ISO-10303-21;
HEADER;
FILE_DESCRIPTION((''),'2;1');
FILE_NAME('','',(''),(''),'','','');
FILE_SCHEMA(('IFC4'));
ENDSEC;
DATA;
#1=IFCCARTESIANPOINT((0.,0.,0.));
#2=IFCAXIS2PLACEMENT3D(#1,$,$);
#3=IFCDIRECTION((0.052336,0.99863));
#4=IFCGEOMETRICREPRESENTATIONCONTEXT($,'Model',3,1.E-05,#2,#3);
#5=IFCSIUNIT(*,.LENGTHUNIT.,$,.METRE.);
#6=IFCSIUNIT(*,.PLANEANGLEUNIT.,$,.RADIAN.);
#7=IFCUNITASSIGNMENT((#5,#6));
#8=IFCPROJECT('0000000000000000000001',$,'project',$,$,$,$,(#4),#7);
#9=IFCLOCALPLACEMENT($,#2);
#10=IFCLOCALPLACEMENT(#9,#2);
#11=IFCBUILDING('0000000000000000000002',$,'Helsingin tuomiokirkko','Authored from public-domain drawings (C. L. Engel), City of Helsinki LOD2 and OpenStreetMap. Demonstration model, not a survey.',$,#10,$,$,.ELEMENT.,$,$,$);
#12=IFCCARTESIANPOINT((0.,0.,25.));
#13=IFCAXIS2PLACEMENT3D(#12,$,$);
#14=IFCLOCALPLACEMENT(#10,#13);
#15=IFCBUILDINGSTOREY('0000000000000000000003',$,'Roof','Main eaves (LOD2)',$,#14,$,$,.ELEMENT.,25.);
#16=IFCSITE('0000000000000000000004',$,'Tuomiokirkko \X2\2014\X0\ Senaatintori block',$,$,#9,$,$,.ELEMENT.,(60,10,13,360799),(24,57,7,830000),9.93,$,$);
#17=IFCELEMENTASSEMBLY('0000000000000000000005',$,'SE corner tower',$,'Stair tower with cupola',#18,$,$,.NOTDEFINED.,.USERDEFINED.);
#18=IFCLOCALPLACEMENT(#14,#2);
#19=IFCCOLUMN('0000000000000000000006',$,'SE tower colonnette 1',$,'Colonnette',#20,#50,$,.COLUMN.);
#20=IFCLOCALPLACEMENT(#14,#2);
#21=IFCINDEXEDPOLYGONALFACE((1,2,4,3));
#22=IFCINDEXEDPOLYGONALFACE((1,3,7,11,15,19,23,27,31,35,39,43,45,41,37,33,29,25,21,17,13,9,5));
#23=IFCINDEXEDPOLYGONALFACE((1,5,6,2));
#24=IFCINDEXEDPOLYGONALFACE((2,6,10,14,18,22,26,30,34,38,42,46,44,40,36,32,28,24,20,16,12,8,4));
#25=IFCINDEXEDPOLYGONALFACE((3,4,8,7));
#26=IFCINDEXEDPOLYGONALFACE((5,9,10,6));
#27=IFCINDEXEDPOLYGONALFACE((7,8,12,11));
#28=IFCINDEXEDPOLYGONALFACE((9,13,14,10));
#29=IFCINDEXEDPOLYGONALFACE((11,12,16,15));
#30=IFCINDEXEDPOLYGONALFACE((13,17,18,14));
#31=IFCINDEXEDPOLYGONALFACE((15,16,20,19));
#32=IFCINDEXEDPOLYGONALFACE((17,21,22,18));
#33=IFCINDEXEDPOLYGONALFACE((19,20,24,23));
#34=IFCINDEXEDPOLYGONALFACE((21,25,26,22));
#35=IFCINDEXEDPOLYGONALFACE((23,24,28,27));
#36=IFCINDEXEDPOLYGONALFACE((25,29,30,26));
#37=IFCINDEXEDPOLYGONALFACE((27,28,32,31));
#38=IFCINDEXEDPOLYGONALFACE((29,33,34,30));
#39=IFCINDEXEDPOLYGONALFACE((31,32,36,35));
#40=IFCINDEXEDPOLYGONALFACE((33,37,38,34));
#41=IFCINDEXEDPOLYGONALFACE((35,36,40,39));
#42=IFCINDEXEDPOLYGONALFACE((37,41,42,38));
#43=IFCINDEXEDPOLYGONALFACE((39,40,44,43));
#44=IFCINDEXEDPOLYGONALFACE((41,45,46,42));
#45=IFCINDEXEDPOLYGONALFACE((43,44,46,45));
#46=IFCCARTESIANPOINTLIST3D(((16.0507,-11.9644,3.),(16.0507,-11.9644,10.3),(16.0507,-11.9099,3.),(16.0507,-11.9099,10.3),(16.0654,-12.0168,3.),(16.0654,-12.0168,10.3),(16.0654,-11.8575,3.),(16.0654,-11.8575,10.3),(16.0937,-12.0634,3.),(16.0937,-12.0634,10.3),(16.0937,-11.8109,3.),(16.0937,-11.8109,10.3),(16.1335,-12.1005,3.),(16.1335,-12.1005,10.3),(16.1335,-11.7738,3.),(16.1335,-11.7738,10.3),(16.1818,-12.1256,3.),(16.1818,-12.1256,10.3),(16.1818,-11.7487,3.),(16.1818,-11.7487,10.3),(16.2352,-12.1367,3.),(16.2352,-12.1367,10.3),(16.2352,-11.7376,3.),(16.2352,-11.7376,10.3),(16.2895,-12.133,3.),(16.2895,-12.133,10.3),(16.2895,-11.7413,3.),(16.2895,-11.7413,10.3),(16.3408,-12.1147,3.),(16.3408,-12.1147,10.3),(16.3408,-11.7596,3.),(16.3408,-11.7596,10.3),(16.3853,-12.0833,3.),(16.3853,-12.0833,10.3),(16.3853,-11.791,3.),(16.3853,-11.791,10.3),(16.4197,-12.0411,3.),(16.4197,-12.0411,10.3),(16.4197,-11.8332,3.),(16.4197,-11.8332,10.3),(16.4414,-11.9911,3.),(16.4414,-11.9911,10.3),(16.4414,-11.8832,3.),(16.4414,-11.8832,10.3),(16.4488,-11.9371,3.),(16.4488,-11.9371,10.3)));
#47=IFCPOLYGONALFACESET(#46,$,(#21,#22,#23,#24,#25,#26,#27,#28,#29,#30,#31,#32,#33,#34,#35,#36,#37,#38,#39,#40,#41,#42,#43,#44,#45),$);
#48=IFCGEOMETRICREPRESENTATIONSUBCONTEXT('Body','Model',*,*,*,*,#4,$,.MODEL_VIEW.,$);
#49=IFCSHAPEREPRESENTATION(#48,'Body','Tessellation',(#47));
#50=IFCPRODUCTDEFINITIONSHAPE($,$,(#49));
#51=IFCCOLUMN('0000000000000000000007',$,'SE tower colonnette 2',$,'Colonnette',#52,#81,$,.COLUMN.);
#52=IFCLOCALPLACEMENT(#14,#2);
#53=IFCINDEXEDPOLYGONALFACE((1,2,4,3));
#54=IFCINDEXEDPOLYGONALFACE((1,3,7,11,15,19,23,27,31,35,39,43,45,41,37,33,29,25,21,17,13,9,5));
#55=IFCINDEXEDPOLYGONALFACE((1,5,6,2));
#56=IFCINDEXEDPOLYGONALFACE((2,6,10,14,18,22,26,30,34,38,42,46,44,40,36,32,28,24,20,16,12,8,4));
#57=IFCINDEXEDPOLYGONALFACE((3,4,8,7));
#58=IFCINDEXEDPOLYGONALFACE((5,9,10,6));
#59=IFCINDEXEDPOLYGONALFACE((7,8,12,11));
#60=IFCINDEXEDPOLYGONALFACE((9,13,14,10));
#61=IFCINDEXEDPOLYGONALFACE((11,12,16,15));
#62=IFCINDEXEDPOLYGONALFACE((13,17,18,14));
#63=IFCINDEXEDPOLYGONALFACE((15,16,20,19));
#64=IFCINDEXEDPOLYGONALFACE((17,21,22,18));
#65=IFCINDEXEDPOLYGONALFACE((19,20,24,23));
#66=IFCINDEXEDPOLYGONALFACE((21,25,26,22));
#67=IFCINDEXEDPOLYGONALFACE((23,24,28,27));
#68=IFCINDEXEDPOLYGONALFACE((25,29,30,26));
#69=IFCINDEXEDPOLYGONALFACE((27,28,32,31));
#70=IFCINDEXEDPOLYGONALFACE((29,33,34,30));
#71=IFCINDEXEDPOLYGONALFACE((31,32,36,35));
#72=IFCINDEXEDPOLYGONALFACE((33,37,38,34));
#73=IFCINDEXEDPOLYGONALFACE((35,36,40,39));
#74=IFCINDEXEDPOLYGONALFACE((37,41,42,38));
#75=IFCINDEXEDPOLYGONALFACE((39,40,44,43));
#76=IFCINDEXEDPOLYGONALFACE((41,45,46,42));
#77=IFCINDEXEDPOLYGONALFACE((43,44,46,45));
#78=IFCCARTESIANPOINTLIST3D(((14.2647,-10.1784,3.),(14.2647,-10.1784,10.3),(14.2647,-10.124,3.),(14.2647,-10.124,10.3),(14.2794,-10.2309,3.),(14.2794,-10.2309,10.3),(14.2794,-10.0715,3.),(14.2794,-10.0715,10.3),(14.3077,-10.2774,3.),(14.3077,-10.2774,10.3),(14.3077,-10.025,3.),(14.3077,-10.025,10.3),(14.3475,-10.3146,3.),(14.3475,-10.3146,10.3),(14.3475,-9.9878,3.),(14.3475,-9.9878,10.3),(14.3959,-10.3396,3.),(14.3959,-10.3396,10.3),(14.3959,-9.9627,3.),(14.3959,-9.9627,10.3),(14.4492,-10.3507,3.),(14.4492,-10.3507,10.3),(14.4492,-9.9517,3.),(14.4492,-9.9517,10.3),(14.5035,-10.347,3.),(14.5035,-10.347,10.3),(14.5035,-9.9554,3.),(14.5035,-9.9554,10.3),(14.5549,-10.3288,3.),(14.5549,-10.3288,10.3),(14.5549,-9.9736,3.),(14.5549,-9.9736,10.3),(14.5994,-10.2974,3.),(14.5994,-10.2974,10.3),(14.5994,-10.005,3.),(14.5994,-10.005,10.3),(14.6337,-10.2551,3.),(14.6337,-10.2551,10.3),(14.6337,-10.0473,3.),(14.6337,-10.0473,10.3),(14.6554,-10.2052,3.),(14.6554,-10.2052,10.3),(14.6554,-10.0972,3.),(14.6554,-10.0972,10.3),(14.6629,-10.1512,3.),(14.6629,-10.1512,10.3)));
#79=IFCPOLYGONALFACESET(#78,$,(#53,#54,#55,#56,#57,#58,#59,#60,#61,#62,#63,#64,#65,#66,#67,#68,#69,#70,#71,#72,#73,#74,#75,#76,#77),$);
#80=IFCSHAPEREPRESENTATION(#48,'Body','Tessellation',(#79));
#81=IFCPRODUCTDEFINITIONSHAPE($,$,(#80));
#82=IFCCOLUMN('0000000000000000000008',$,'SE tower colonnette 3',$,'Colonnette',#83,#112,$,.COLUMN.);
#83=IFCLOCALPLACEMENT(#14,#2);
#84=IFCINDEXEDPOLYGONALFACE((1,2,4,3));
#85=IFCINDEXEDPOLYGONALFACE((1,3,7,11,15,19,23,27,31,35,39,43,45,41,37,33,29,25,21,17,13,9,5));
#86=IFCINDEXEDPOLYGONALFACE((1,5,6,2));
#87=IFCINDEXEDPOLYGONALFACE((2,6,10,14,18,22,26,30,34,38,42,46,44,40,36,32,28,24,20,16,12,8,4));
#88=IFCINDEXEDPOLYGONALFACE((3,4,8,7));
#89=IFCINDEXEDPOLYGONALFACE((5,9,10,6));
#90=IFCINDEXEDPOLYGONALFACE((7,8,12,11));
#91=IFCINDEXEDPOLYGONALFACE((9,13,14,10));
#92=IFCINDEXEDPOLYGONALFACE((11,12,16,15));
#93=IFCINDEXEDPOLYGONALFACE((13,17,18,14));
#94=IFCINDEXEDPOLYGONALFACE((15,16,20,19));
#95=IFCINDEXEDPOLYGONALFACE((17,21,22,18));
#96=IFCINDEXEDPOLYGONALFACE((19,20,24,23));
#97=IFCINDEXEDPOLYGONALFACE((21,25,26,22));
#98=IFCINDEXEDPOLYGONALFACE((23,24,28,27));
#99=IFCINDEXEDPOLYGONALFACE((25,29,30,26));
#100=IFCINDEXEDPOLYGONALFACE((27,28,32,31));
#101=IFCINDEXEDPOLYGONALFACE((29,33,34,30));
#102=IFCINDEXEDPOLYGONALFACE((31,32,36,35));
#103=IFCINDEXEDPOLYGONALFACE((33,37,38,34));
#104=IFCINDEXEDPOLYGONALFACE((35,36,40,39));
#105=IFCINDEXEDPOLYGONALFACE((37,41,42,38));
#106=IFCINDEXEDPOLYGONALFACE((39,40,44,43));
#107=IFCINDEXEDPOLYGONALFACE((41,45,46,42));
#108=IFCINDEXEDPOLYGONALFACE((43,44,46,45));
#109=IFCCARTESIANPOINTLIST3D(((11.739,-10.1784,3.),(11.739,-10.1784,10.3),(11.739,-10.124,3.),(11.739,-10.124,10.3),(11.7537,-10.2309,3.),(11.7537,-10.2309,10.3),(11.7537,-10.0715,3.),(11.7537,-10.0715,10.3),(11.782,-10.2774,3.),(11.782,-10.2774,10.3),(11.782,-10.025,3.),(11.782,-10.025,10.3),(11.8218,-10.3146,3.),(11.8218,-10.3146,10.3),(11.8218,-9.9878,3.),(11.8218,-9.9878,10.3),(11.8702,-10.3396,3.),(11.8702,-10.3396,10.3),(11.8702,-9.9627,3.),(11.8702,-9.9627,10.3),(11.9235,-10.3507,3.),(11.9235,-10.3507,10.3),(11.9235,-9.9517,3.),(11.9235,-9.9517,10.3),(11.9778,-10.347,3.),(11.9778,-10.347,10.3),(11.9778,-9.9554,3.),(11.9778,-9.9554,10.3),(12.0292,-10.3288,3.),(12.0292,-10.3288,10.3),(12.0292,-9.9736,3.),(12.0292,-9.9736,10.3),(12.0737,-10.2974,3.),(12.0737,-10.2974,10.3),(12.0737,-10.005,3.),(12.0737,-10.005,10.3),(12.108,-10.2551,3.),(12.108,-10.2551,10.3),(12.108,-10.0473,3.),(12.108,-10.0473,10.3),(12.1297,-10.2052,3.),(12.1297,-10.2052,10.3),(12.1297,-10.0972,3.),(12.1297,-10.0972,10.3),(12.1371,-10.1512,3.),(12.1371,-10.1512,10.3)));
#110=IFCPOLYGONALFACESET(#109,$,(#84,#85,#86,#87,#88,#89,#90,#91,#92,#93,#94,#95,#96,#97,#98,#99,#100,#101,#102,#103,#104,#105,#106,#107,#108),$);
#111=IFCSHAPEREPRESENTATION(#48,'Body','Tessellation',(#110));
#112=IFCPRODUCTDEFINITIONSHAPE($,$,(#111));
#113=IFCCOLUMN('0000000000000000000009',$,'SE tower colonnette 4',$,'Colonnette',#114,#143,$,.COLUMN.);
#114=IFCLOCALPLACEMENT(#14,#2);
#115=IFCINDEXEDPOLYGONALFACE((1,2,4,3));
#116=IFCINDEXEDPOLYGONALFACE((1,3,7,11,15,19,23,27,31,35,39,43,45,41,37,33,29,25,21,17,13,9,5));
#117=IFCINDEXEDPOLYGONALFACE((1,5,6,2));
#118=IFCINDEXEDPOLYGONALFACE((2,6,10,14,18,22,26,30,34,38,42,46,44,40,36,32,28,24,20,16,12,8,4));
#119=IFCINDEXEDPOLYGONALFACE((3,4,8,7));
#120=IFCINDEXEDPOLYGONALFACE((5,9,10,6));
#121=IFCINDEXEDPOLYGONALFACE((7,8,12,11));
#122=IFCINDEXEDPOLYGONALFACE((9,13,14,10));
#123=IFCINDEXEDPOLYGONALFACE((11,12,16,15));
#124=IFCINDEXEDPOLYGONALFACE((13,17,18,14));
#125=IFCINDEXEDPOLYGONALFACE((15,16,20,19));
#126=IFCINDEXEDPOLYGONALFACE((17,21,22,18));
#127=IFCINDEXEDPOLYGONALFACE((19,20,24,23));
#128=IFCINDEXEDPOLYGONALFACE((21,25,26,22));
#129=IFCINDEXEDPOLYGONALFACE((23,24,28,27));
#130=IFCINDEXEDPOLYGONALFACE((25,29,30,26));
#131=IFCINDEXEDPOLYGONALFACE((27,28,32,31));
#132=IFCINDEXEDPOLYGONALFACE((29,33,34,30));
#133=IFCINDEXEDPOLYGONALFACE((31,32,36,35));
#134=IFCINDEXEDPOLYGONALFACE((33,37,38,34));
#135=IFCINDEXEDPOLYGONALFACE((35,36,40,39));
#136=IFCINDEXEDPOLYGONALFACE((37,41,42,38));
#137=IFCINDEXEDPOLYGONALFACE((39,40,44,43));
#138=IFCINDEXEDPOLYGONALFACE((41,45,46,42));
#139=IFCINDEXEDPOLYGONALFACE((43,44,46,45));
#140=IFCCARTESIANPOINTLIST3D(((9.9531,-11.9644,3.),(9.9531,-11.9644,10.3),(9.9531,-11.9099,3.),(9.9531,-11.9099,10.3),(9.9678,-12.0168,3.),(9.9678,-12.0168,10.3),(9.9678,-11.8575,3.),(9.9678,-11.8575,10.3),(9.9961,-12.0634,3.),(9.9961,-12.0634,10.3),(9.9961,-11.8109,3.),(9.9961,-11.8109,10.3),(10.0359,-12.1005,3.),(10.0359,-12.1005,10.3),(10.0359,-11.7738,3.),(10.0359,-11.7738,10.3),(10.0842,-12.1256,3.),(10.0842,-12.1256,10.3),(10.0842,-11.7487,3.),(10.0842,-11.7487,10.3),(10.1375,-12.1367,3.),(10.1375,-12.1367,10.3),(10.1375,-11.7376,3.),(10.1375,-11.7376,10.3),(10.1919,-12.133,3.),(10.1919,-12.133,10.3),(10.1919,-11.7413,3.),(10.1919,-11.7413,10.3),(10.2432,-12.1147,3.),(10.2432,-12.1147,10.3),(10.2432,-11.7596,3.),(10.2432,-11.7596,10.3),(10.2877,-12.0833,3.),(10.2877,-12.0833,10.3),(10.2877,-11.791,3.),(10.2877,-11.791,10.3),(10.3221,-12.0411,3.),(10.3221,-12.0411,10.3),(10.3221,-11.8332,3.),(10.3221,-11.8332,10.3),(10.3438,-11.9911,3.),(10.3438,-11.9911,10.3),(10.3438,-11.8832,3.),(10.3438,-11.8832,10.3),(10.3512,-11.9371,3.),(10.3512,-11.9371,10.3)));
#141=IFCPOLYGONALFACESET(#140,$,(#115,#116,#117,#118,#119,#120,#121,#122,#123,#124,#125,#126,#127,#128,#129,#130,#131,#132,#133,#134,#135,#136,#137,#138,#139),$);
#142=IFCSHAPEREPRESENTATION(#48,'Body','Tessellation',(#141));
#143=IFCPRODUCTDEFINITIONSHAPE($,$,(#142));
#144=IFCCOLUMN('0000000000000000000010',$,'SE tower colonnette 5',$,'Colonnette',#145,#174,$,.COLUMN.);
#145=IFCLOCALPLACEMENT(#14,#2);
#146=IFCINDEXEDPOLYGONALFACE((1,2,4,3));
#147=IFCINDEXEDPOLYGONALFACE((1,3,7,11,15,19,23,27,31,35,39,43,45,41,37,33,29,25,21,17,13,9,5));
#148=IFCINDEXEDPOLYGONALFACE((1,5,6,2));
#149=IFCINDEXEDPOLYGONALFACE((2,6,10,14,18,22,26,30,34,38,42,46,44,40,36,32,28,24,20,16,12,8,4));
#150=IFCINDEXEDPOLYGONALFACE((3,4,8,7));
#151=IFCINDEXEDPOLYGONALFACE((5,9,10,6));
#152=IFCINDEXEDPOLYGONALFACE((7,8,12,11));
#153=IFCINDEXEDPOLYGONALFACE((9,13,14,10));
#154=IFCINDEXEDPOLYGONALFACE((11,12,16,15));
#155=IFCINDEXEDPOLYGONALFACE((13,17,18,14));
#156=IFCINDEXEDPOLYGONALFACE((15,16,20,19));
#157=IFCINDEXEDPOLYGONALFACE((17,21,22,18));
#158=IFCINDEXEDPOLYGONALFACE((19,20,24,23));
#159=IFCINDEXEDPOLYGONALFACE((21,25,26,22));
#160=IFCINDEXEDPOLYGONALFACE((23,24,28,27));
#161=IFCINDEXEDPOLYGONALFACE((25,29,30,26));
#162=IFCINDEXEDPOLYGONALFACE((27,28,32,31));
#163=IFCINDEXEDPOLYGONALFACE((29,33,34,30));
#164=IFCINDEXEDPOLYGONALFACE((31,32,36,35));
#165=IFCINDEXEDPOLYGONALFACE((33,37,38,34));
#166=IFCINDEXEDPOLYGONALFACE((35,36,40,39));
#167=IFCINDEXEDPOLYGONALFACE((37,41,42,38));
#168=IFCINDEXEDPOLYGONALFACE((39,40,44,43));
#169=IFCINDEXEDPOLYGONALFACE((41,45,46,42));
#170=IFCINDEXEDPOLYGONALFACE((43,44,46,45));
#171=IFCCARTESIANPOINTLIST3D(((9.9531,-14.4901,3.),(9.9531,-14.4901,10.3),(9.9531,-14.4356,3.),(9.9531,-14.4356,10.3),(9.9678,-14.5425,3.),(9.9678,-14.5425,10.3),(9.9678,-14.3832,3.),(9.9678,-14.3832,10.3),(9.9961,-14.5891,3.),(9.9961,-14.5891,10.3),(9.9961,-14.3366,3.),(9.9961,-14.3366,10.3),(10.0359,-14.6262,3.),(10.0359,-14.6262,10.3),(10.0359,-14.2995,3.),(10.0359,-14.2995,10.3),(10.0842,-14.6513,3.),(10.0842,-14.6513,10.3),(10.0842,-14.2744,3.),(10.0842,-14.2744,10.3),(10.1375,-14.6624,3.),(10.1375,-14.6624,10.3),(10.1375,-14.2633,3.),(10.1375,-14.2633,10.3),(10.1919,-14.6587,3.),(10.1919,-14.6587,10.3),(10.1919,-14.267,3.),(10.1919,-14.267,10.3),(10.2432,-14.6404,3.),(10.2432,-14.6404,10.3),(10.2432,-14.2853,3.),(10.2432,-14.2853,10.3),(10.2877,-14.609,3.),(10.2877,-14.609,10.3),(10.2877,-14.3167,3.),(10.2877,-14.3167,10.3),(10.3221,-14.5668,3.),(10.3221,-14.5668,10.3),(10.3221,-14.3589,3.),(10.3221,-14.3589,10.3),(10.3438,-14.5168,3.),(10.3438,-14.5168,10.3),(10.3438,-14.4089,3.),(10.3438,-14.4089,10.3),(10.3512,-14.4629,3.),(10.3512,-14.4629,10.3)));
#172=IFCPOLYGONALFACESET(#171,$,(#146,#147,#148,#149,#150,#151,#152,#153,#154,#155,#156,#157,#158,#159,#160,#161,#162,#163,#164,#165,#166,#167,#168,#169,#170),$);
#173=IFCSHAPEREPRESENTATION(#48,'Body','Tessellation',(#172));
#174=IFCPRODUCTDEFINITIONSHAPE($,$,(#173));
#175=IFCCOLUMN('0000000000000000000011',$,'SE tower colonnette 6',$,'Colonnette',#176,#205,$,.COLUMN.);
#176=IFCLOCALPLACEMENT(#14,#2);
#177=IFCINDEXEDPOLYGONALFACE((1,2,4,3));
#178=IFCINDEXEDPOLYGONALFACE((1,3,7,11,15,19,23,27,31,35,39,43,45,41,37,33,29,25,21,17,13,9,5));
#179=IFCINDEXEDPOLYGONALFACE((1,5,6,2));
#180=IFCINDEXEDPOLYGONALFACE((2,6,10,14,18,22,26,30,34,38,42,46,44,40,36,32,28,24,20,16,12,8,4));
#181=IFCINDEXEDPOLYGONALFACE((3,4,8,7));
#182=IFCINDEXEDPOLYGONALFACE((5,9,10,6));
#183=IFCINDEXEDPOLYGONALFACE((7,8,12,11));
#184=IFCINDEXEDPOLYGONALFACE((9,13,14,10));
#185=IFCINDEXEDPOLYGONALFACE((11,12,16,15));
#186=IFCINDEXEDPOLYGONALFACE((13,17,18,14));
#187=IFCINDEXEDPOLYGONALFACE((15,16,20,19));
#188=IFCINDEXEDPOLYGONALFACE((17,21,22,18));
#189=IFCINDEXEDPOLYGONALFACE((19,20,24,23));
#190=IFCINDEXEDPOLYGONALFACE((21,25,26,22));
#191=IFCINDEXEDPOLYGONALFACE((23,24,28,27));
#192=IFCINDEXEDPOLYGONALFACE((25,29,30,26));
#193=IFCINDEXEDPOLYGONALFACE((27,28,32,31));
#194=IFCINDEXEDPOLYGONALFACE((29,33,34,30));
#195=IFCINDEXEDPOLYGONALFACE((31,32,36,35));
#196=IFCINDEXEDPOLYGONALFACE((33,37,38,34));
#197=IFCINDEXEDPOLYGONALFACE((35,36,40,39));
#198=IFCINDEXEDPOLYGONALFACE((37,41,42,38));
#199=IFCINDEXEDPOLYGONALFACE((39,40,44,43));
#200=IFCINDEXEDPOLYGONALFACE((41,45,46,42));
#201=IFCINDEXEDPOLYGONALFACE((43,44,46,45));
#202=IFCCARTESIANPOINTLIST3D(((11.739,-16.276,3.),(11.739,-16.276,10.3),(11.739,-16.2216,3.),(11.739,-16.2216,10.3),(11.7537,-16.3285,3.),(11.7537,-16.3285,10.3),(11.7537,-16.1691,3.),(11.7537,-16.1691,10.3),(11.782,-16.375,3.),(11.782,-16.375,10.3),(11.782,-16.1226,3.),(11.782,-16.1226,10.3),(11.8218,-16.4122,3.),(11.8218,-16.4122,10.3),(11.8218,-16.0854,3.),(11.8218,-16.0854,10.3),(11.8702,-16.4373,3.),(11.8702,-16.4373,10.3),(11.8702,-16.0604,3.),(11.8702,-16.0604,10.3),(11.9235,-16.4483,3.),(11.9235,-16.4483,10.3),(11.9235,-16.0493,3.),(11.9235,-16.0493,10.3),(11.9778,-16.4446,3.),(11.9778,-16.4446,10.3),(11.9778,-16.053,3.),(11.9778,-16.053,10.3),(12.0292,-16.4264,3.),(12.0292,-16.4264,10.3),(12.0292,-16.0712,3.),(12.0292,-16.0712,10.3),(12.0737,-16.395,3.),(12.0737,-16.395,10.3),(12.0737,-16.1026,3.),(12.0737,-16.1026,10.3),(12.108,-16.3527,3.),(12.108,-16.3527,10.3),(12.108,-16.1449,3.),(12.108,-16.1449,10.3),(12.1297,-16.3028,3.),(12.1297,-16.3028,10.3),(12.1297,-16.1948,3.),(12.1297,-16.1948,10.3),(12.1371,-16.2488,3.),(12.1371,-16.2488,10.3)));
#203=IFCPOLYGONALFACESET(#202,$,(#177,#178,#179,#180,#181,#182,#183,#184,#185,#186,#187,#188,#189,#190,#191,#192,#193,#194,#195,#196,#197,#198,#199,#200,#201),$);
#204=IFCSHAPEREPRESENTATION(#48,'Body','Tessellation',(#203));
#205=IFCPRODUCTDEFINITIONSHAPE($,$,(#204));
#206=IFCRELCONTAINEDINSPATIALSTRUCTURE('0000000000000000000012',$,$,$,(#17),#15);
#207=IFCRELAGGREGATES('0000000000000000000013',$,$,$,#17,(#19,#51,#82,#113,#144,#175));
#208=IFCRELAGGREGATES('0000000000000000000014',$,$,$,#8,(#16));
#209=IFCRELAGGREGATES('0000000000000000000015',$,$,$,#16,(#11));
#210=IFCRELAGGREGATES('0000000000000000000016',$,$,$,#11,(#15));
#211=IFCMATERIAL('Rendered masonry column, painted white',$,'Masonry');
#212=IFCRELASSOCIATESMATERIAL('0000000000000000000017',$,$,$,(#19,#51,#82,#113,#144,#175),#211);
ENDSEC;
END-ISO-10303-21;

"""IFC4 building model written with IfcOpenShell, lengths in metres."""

from ifc_helpers import new_model, si_unit, direction, frame, origin, origin_2d_with_axis, place, context, subcontext, project, spatial, circle, extrude, material, element, aggregate, save


model = new_model("IFC4")

# Units and contexts
model_context = context("Model", 3, precision=1e-05, world=origin(), true_north=direction((0.052336, 0.99863)))
body_context = subcontext(model_context, "Body", "Model", "MODEL_VIEW")
ifc_project = project(units=[si_unit("LENGTHUNIT", "METRE"), si_unit("PLANEANGLEUNIT", "RADIAN")], contexts=[model_context])

# Site, building, storey
site_placement = place(None, origin())
site = spatial("IfcSite", under=ifc_project, at=site_placement, Name="Tuomiokirkko — Senaatintori block", CompositionType="ELEMENT", RefLatitude=(60, 10, 13, 360799), RefLongitude=(24, 57, 7, 830000), RefElevation=9.93)
building_placement = place(site_placement, origin())
building = spatial("IfcBuilding", under=site, at=building_placement, Name="Helsingin tuomiokirkko", Description="Authored from public-domain drawings (C. L. Engel), City of Helsinki LOD2 and OpenStreetMap. Demonstration model, not a survey.", CompositionType="ELEMENT")
storey_placement = place(building_placement, frame((0.0, 0.0, 25.0)))
storey = spatial("IfcBuildingStorey", under=building, at=storey_placement, Name="Roof", Description="Main eaves (LOD2)", CompositionType="ELEMENT", Elevation=25.0)

# Element assembly, columns
assembly_1_placement = place(building_placement, origin())
assembly_1 = element("IfcElementAssembly", 1, at=assembly_1_placement, inside=storey, Name="SE corner tower", ObjectType="Stair tower with cupola", AssemblyPlace="NOTDEFINED", PredefinedType="USERDEFINED")
ifc_material_1 = material(Name="Rendered masonry column, painted white", Category="Masonry")
column_1_placement = place(building_placement, origin())
column_1 = element("IfcColumn", 2, at=column_1_placement, material=ifc_material_1, Name="SE tower colonnette 1", ObjectType="Colonnette", PredefinedType="COLUMN", context=body_context, shape_type="SweptSolid", body=[
    extrude(circle(Radius=0.2, at=origin_2d_with_axis()), frame((16.2488, -11.9371, 28.0)), (0.0, 0.0, 1.0), 7.3),
])
column_2_placement = place(building_placement, origin())
column_2 = element("IfcColumn", 3, at=column_2_placement, material=ifc_material_1, Name="SE tower colonnette 2", ObjectType="Colonnette", PredefinedType="COLUMN", context=body_context, shape_type="SweptSolid", body=[
    extrude(circle(Radius=0.2, at=origin_2d_with_axis()), frame((14.4629, -10.1512, 28.0)), (0.0, 0.0, 1.0), 7.3),
])
column_3_placement = place(building_placement, origin())
column_3 = element("IfcColumn", 4, at=column_3_placement, material=ifc_material_1, Name="SE tower colonnette 3", ObjectType="Colonnette", PredefinedType="COLUMN", context=body_context, shape_type="SweptSolid", body=[
    extrude(circle(Radius=0.2, at=origin_2d_with_axis()), frame((11.9371, -10.1512, 28.0)), (0.0, 0.0, 1.0), 7.3),
])
column_4_placement = place(building_placement, origin())
column_4 = element("IfcColumn", 5, at=column_4_placement, material=ifc_material_1, Name="SE tower colonnette 4", ObjectType="Colonnette", PredefinedType="COLUMN", context=body_context, shape_type="SweptSolid", body=[
    extrude(circle(Radius=0.2, at=origin_2d_with_axis()), frame((10.1512, -11.9371, 28.0)), (0.0, 0.0, 1.0), 7.3),
])
column_5_placement = place(building_placement, origin())
column_5 = element("IfcColumn", 6, at=column_5_placement, material=ifc_material_1, Name="SE tower colonnette 5", ObjectType="Colonnette", PredefinedType="COLUMN", context=body_context, shape_type="SweptSolid", body=[
    extrude(circle(Radius=0.2, at=origin_2d_with_axis()), frame((10.1512, -14.4629, 28.0)), (0.0, 0.0, 1.0), 7.3),
])
column_6_placement = place(building_placement, origin())
column_6 = element("IfcColumn", 7, at=column_6_placement, material=ifc_material_1, Name="SE tower colonnette 6", ObjectType="Colonnette", PredefinedType="COLUMN", context=body_context, shape_type="SweptSolid", body=[
    extrude(circle(Radius=0.2, at=origin_2d_with_axis()), frame((11.9371, -16.2488, 28.0)), (0.0, 0.0, 1.0), 7.3),
])

aggregate(assembly_1, [column_1, column_2, column_3, column_4, column_5, column_6])

save(model, "model.ifc")
